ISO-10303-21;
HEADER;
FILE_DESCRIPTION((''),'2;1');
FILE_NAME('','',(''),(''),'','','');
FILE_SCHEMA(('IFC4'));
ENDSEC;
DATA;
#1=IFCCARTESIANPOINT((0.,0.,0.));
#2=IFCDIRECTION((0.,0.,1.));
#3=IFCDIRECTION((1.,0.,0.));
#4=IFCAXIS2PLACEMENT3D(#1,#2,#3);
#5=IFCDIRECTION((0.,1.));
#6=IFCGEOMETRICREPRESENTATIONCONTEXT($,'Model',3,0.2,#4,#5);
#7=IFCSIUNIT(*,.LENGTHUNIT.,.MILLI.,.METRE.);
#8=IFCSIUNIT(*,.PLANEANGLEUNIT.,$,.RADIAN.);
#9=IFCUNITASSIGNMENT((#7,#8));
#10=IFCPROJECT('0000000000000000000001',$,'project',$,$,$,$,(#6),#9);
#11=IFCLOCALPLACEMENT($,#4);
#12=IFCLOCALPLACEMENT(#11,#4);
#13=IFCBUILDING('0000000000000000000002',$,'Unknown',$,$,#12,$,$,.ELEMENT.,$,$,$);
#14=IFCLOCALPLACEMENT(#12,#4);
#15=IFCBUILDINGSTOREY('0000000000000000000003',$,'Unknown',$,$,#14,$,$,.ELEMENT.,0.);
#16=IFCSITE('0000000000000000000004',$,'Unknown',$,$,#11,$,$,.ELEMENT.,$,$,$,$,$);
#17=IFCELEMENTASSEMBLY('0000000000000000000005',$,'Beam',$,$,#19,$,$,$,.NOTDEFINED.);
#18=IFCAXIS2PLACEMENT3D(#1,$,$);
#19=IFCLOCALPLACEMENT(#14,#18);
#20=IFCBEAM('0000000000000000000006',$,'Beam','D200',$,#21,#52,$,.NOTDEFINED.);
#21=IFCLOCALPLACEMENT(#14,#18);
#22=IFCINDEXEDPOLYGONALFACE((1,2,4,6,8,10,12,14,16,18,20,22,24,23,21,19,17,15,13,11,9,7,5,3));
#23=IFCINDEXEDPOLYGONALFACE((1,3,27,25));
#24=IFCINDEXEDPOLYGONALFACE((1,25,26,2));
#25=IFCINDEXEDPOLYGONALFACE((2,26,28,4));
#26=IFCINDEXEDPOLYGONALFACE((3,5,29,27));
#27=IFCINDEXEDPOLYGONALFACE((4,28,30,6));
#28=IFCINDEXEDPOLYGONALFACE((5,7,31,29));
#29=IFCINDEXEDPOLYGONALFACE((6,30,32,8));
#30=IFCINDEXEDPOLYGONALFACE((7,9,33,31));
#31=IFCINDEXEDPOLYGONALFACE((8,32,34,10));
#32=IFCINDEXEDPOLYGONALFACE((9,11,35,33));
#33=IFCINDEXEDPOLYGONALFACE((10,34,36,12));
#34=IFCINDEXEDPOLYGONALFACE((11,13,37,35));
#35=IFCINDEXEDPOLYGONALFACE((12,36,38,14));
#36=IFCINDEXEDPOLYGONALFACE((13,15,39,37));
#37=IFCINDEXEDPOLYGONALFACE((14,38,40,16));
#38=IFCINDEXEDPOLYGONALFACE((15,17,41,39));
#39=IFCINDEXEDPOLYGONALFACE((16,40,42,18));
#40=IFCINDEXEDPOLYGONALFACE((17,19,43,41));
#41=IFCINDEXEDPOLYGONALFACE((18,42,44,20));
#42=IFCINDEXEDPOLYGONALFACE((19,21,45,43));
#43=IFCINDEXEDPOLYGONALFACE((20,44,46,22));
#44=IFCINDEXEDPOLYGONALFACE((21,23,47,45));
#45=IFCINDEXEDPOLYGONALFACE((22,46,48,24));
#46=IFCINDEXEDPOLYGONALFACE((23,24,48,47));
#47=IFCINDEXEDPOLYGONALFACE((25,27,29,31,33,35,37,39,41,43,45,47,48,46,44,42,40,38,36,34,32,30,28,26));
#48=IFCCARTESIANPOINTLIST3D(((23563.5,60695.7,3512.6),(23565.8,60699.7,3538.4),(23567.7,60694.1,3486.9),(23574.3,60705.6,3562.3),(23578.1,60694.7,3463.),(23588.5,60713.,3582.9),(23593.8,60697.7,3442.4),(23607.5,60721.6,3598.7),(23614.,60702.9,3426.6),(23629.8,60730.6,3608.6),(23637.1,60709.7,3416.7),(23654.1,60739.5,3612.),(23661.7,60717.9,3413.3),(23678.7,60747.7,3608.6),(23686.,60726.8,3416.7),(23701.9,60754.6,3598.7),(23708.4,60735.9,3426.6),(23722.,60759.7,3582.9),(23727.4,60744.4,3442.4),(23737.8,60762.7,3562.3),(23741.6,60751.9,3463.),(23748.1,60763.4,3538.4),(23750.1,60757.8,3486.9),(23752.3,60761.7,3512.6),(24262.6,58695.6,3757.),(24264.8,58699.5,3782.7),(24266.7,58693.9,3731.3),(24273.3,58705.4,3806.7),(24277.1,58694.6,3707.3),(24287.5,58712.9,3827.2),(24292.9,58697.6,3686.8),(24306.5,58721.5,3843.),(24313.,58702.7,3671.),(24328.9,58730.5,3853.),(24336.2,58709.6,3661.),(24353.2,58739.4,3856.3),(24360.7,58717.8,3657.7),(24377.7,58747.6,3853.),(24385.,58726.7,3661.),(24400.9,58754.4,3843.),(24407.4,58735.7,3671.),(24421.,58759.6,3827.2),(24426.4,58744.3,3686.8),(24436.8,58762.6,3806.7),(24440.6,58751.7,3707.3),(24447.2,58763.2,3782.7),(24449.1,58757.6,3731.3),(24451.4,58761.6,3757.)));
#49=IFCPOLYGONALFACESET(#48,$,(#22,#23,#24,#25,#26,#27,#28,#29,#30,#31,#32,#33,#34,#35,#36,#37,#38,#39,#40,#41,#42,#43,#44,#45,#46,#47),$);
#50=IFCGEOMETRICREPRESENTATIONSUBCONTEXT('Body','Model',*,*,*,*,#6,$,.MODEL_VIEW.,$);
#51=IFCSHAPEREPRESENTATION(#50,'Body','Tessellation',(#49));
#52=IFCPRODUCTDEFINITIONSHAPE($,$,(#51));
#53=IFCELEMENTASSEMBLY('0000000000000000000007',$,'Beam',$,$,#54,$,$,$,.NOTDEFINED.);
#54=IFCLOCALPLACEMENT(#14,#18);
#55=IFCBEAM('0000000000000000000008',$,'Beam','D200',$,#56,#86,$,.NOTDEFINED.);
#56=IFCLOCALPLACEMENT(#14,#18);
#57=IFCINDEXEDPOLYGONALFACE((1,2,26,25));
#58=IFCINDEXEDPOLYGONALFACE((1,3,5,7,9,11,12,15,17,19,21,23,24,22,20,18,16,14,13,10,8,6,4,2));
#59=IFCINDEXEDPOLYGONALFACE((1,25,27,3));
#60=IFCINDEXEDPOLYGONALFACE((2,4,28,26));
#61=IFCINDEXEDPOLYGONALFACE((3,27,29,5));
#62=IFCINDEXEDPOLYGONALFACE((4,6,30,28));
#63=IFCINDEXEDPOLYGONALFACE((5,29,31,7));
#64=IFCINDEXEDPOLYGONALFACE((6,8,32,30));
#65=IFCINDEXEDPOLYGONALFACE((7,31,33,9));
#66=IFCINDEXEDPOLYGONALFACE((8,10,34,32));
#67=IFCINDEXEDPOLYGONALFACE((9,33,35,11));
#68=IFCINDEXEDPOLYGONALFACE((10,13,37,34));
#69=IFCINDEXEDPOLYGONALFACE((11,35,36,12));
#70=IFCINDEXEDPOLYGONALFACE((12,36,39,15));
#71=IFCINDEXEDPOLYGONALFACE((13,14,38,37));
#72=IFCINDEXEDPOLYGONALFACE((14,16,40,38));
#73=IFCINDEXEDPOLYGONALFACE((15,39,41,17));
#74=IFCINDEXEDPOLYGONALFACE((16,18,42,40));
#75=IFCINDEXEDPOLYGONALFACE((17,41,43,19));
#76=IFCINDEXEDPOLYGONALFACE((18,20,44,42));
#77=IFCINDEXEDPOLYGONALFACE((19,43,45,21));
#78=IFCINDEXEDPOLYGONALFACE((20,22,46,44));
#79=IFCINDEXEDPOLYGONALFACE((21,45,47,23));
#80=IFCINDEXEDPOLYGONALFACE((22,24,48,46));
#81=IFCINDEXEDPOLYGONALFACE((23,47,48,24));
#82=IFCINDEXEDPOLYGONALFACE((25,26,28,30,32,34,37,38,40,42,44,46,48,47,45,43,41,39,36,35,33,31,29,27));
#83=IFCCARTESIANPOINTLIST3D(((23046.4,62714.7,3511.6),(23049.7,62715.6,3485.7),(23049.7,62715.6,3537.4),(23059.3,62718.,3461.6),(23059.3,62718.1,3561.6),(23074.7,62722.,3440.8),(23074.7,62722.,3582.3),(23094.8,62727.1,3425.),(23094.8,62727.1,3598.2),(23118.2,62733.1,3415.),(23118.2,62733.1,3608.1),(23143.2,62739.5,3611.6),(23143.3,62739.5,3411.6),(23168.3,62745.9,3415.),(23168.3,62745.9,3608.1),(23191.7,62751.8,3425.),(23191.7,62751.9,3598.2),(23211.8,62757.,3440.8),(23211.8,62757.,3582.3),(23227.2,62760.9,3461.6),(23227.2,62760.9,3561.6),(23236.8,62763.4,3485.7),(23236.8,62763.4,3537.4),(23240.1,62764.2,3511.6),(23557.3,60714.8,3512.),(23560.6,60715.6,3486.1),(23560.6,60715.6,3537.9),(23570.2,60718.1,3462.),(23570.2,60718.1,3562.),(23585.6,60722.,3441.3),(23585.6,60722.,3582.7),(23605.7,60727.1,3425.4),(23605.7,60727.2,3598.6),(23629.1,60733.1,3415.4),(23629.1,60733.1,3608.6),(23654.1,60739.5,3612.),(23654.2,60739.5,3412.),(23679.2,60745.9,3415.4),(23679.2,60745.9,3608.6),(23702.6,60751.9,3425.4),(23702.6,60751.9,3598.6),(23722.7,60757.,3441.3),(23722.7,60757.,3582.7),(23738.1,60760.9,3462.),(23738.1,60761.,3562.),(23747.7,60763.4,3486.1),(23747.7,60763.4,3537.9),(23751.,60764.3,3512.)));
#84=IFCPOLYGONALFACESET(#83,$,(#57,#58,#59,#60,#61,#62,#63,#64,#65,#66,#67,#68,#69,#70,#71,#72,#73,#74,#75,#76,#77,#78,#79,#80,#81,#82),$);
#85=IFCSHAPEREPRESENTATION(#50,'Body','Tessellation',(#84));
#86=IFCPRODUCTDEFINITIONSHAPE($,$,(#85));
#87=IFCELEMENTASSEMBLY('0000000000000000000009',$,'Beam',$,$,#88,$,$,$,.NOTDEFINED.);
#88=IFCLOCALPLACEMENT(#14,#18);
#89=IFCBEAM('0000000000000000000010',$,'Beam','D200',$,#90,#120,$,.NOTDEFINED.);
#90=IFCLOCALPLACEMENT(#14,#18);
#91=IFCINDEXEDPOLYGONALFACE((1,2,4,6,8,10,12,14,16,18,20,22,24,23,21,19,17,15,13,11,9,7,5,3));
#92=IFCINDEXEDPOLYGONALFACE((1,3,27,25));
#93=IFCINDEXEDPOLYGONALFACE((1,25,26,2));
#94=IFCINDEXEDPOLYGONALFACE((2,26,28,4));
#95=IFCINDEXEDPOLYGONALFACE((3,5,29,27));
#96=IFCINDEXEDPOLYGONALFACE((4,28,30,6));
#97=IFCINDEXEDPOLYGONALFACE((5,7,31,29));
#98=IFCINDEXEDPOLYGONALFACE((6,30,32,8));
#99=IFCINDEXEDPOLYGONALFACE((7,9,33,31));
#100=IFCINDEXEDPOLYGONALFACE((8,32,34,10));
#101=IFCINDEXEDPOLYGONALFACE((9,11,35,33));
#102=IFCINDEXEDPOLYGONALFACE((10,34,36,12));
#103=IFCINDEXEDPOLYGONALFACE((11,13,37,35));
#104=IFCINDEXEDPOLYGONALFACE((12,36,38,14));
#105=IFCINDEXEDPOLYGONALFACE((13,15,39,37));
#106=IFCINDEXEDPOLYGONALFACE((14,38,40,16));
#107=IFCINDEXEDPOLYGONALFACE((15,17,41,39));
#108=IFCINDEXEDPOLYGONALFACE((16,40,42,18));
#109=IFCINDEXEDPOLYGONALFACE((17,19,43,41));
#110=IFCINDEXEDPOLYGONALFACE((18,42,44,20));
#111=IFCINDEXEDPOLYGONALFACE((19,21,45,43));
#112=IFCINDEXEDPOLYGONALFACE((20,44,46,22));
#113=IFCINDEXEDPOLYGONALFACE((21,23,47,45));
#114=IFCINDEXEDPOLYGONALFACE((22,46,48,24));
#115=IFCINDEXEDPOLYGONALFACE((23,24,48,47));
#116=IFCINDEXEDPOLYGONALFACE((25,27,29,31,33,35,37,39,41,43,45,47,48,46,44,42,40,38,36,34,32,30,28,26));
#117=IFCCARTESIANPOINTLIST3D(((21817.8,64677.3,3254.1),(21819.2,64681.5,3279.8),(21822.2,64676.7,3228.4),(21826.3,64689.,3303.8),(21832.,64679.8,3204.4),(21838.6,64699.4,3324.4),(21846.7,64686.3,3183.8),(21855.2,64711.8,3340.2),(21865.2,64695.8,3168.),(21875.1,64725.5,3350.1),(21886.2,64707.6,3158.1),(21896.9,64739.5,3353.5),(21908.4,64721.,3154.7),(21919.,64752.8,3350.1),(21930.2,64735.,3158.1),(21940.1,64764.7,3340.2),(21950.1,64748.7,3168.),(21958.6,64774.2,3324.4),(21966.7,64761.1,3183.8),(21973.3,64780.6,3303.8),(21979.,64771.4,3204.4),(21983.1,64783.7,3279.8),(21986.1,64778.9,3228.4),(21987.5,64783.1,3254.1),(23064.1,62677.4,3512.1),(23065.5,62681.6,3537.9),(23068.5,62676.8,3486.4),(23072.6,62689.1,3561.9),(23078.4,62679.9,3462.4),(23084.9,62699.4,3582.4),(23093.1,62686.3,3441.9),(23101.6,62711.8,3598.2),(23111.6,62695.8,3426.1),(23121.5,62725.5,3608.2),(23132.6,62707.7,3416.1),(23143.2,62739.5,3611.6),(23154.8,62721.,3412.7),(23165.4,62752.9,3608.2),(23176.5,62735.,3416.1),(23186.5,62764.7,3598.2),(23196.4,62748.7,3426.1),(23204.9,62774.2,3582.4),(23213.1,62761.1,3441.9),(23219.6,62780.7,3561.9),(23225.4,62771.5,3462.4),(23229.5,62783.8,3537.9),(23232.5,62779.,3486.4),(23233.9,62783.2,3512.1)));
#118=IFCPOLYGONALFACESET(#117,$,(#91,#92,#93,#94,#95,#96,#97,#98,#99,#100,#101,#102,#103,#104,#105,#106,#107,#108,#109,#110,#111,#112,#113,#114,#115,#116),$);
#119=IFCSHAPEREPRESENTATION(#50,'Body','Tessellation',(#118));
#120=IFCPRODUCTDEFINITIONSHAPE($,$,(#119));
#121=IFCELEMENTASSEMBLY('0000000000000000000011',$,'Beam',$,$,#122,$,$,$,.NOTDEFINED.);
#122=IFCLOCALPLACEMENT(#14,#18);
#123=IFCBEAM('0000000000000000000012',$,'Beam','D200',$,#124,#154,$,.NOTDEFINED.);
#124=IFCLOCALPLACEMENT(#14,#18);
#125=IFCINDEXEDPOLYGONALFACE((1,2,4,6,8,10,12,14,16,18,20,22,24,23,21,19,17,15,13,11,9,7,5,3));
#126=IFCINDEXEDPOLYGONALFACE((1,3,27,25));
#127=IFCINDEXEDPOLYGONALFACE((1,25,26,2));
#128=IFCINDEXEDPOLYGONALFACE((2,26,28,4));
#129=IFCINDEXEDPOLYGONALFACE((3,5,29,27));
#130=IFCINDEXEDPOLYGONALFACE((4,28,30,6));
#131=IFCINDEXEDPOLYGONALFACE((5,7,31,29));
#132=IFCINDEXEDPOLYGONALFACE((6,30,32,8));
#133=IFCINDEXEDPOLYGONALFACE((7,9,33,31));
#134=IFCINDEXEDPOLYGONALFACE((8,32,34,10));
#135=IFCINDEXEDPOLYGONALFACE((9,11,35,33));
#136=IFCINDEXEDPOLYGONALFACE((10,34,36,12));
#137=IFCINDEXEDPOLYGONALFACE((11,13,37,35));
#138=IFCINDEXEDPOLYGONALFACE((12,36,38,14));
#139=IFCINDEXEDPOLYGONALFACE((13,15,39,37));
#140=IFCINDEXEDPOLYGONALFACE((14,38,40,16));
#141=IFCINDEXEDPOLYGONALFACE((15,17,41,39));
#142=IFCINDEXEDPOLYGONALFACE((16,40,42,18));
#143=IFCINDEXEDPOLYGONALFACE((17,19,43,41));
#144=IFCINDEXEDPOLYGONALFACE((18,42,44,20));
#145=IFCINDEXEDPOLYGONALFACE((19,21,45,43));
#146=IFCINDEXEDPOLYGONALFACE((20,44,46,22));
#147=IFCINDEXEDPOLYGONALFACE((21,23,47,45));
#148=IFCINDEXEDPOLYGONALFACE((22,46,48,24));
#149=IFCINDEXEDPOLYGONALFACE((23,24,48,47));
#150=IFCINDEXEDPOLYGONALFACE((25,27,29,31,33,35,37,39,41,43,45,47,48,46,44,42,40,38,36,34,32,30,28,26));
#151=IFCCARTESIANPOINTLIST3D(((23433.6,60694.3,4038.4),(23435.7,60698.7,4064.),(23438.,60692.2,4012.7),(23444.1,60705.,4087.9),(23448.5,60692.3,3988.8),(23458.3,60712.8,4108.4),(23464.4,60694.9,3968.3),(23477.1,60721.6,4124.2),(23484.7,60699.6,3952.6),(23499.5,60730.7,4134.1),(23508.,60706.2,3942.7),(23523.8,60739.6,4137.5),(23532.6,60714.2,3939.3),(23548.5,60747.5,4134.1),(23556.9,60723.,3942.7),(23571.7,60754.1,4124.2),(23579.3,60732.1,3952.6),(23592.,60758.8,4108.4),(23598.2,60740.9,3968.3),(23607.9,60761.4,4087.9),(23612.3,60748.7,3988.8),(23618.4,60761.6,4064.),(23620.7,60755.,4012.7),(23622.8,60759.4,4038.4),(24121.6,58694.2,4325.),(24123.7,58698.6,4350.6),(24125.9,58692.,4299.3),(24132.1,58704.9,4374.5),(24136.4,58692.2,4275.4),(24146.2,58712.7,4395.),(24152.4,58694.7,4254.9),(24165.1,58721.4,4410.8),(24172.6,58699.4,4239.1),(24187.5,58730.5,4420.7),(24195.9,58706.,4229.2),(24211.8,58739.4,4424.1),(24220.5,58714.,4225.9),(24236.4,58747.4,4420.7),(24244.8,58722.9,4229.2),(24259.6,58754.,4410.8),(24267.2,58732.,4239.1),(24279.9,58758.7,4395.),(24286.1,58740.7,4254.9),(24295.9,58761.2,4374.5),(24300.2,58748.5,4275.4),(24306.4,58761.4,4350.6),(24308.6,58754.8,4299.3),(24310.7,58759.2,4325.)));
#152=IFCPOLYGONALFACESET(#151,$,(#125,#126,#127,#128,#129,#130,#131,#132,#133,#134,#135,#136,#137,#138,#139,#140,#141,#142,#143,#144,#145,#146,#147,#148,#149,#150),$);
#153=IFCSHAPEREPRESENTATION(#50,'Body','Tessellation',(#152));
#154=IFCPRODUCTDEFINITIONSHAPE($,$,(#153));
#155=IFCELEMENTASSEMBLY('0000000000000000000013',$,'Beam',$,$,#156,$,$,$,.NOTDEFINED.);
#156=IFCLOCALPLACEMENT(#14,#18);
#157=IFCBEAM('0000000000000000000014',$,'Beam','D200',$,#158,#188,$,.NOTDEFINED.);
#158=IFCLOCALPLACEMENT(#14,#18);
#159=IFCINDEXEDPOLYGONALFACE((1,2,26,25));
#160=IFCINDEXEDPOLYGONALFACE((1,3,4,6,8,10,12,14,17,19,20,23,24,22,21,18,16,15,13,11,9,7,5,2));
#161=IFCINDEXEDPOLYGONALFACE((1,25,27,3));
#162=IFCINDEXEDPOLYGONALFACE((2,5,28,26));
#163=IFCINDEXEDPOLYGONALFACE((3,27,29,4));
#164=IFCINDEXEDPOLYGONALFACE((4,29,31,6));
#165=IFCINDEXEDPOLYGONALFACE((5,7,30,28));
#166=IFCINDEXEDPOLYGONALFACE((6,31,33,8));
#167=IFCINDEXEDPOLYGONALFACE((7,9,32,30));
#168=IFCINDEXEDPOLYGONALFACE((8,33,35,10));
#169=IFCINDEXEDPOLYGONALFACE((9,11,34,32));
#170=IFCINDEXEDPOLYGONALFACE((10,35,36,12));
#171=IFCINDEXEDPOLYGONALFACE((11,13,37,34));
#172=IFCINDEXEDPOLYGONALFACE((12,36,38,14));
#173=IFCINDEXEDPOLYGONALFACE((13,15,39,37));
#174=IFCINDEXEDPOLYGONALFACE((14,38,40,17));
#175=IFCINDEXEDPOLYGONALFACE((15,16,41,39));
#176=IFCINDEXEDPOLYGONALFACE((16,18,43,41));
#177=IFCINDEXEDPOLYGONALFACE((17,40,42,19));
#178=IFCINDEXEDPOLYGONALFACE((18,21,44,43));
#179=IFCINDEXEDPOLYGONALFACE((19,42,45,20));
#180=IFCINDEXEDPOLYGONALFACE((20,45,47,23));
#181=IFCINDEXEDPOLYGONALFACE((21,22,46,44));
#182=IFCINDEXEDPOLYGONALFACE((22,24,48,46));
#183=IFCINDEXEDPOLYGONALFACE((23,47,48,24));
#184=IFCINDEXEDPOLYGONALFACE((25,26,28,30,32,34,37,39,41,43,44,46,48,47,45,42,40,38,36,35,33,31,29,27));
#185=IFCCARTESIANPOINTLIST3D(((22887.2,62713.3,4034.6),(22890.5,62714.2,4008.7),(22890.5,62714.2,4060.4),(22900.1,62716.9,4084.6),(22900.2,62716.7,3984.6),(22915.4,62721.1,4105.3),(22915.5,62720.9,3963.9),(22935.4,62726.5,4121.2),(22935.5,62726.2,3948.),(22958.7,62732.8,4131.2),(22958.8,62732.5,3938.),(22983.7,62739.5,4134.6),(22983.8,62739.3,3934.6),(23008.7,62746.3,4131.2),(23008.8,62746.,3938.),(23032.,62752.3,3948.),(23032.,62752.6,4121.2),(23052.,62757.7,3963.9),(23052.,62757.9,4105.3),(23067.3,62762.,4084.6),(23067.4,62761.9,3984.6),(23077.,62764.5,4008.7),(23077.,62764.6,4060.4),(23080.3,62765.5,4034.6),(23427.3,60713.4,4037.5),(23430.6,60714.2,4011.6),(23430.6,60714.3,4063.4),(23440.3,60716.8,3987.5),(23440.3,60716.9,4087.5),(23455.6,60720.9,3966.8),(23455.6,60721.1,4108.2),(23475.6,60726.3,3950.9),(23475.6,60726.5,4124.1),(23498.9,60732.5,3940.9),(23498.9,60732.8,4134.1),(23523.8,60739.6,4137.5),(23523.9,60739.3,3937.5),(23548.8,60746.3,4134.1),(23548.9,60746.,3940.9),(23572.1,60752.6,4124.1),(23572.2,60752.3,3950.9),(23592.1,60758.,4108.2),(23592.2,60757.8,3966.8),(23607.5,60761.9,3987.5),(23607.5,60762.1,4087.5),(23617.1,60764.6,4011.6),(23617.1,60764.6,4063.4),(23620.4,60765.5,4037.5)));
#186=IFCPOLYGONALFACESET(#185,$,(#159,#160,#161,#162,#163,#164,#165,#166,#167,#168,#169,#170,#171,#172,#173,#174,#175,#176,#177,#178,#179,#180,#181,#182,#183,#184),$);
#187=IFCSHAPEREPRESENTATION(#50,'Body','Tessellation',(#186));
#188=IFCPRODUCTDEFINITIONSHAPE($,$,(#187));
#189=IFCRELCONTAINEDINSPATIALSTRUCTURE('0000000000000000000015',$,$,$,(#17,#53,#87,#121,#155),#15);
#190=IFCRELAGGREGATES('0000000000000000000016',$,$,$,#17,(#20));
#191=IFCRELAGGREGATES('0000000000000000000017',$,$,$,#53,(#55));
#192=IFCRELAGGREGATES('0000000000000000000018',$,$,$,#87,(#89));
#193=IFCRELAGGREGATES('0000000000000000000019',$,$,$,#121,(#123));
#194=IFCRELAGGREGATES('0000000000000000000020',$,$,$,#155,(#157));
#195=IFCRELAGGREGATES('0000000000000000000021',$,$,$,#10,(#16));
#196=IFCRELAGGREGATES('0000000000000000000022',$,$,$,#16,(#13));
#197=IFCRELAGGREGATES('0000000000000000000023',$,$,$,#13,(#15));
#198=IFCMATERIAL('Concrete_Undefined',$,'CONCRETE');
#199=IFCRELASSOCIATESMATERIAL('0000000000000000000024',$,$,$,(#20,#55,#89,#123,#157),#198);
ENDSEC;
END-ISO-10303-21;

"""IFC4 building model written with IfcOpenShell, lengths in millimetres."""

from ifc_helpers import new_model, si_unit, direction, frame, origin_with_axes, place, context, subcontext, project, spatial, line, indexed_curve, outline, extrude, material, element, aggregate, save


model = new_model("IFC4")

# Units and contexts
model_context = context("Model", 3, precision=0.2, world=origin_with_axes(), true_north=direction((0.0, 1.0)))
body_context = subcontext(model_context, "Body", "Model", "MODEL_VIEW")
ifc_project = project(units=[si_unit("LENGTHUNIT", "METRE", prefix="MILLI"), si_unit("PLANEANGLEUNIT", "RADIAN")], contexts=[model_context])

# Site, building, storey
site_placement = place(None, origin_with_axes())
site = spatial("IfcSite", under=ifc_project, at=site_placement, Name="Unknown", CompositionType="ELEMENT")
building_placement = place(site_placement, origin_with_axes())
building = spatial("IfcBuilding", under=site, at=building_placement, Name="Unknown", CompositionType="ELEMENT")
storey_placement = place(building_placement, origin_with_axes())
storey = spatial("IfcBuildingStorey", under=building, at=storey_placement, Name="Unknown", CompositionType="ELEMENT", Elevation=0.0)

# Element assemblies, beams
ifc_material = material(Name="Concrete_Undefined", Category="CONCRETE")
assembly_1_placement = place(storey_placement, frame((23657.9, 60728.7, 3512.6), z_axis=(-0.944009, -0.329921, 0.0), x_axis=(0.327748, -0.937792, 0.114571)))
assembly_1 = element("IfcElementAssembly", 1, at=assembly_1_placement, inside=storey, Name="Beam", PredefinedType="NOTDEFINED")
beam_1_placement = place(assembly_1_placement, origin_with_axes())
beam_1 = element("IfcBeam", 2, at=beam_1_placement, material=ifc_material, Name="Beam", Description="D200", PredefinedType="NOTDEFINED", context=body_context, shape_type="SolidModel", body=[
    extrude(outline(indexed_curve([(100.0, 0.0), (96.6, 25.9), (86.6, 50.0), (70.7, 70.7), (50.0, 86.6), (25.9, 96.6), (0.0, 100.0), (-25.9, 96.6), (-50.0, 86.6), (-70.7, 70.7), (-86.6, 50.0), (-96.6, 25.9), (-100.0, 0.0), (-96.6, -25.9), (-86.6, -50.0), (-70.7, -70.7), (-50.0, -86.6), (-25.9, -96.6), (0.0, -100.0), (25.9, -96.6), (50.0, -86.6), (70.7, -70.7), (86.6, -50.0), (96.6, -25.9)], segments=[line(1, 2, 3, 4, 5, 6, 7, 8, 9, 10, 11, 12, 13, 14, 15, 16, 17, 18, 19, 20, 21, 22, 23, 24, 1)])), frame((0.0, 0.0, 0.0), z_axis=(-1.0, 0.0, 0.0), x_axis=(0.0, 0.0, 1.0)), (0.0, 0.0, -1.0), 2132.8),
])
aggregate(assembly_1, [beam_1])
assembly_2_placement = place(storey_placement, frame((23143.3, 62739.5, 3511.6), z_axis=(-0.968887, -0.247504, 0.0), x_axis=(0.247504, -0.968887, 0.000208)))
assembly_2 = element("IfcElementAssembly", 3, at=assembly_2_placement, inside=storey, Name="Beam", PredefinedType="NOTDEFINED")
beam_2_placement = place(assembly_2_placement, origin_with_axes())
beam_2 = element("IfcBeam", 4, at=beam_2_placement, material=ifc_material, Name="Beam", Description="D200", PredefinedType="NOTDEFINED", context=body_context, shape_type="SolidModel", body=[
    extrude(outline(indexed_curve([(100.0, 0.0), (96.6, 25.9), (86.6, 50.0), (70.7, 70.7), (50.0, 86.6), (25.9, 96.6), (0.0, 100.0), (-25.9, 96.6), (-50.0, 86.6), (-70.7, 70.7), (-86.6, 50.0), (-96.6, 25.9), (-100.0, 0.0), (-96.6, -25.9), (-86.6, -50.0), (-70.7, -70.7), (-50.0, -86.6), (-25.9, -96.6), (0.0, -100.0), (25.9, -96.6), (50.0, -86.6), (70.7, -70.7), (86.6, -50.0), (96.6, -25.9)], segments=[line(1, 2, 3, 4, 5, 6, 7, 8, 9, 10, 11, 12, 13, 14, 15, 16, 17, 18, 19, 20, 21, 22, 23, 24, 1)])), frame((0.0, 0.0, 0.0), z_axis=(-1.0, 0.0, 0.0), x_axis=(0.0, 0.0, 1.0)), (0.0, 0.0, -1.0), 2064.2),
])
aggregate(assembly_2, [beam_2])
assembly_3_placement = place(storey_placement, frame((21902.6, 64730.2, 3254.1), z_axis=(-0.848685, -0.528898, 0.0), x_axis=(0.525756, -0.843642, 0.10885)))
assembly_3 = element("IfcElementAssembly", 5, at=assembly_3_placement, inside=storey, Name="Beam", PredefinedType="NOTDEFINED")
beam_3_placement = place(assembly_3_placement, origin_with_axes())
beam_3 = element("IfcBeam", 6, at=beam_3_placement, material=ifc_material, Name="Beam", Description="D200", PredefinedType="NOTDEFINED", context=body_context, shape_type="SolidModel", body=[
    extrude(outline(indexed_curve([(100.0, 0.0), (96.6, 25.9), (86.6, 50.0), (70.7, 70.7), (50.0, 86.6), (25.9, 96.6), (0.0, 100.0), (-25.9, 96.6), (-50.0, 86.6), (-70.7, 70.7), (-86.6, 50.0), (-96.6, 25.9), (-100.0, 0.0), (-96.6, -25.9), (-86.6, -50.0), (-70.7, -70.7), (-50.0, -86.6), (-25.9, -96.6), (0.0, -100.0), (25.9, -96.6), (50.0, -86.6), (70.7, -70.7), (86.6, -50.0), (96.6, -25.9)], segments=[line(1, 2, 3, 4, 5, 6, 7, 8, 9, 10, 11, 12, 13, 14, 15, 16, 17, 18, 19, 20, 21, 22, 23, 24, 1)])), frame((0.0, 0.0, 0.0), z_axis=(-1.0, 0.0, 0.0), x_axis=(0.0, 0.0, 1.0)), (0.0, 0.0, -1.0), 2370.6),
])
aggregate(assembly_3, [beam_3])
assembly_4_placement = place(storey_placement, frame((23528.2, 60726.9, 4038.4), z_axis=(-0.945632, -0.325239, 0.0), x_axis=(0.322294, -0.93707, 0.134262)))
assembly_4 = element("IfcElementAssembly", 7, at=assembly_4_placement, inside=storey, Name="Beam", PredefinedType="NOTDEFINED")
beam_4_placement = place(assembly_4_placement, origin_with_axes())
beam_4 = element("IfcBeam", 8, at=beam_4_placement, material=ifc_material, Name="Beam", Description="D200", PredefinedType="NOTDEFINED", context=body_context, shape_type="SolidModel", body=[
    extrude(outline(indexed_curve([(100.0, 0.0), (96.6, 25.9), (86.6, 50.0), (70.7, 70.7), (50.0, 86.6), (25.9, 96.6), (0.0, 100.0), (-25.9, 96.6), (-50.0, 86.6), (-70.7, 70.7), (-86.6, 50.0), (-96.6, 25.9), (-100.0, 0.0), (-96.6, -25.9), (-86.6, -50.0), (-70.7, -70.7), (-50.0, -86.6), (-25.9, -96.6), (0.0, -100.0), (25.9, -96.6), (50.0, -86.6), (70.7, -70.7), (86.6, -50.0), (96.6, -25.9)], segments=[line(1, 2, 3, 4, 5, 6, 7, 8, 9, 10, 11, 12, 13, 14, 15, 16, 17, 18, 19, 20, 21, 22, 23, 24, 1)])), frame((0.0, 0.0, 0.0), z_axis=(-1.0, 0.0, 0.0), x_axis=(0.0, 0.0, 1.0)), (0.0, 0.0, -1.0), 2134.5),
])
aggregate(assembly_4, [beam_4])
assembly_5_placement = place(storey_placement, frame((22983.7, 62739.4, 4034.6), z_axis=(-0.965411, -0.260732, 0.0), x_axis=(0.260732, -0.96541, 0.001403)))
assembly_5 = element("IfcElementAssembly", 9, at=assembly_5_placement, inside=storey, Name="Beam", PredefinedType="NOTDEFINED")
beam_5_placement = place(assembly_5_placement, origin_with_axes())
beam_5 = element("IfcBeam", 10, at=beam_5_placement, material=ifc_material, Name="Beam", Description="D200", PredefinedType="NOTDEFINED", context=body_context, shape_type="SolidModel", body=[
    extrude(outline(indexed_curve([(100.0, 0.0), (96.6, 25.9), (86.6, 50.0), (70.7, 70.7), (50.0, 86.6), (25.9, 96.6), (0.0, 100.0), (-25.9, 96.6), (-50.0, 86.6), (-70.7, 70.7), (-86.6, 50.0), (-96.6, 25.9), (-100.0, 0.0), (-96.6, -25.9), (-86.6, -50.0), (-70.7, -70.7), (-50.0, -86.6), (-25.9, -96.6), (0.0, -100.0), (25.9, -96.6), (50.0, -86.6), (70.7, -70.7), (86.6, -50.0), (96.6, -25.9)], segments=[line(1, 2, 3, 4, 5, 6, 7, 8, 9, 10, 11, 12, 13, 14, 15, 16, 17, 18, 19, 20, 21, 22, 23, 24, 1)])), frame((0.0, 0.0, 0.0), z_axis=(-1.0, 0.0, 0.0), x_axis=(0.0, 0.0, 1.0)), (0.0, 0.0, -1.0), 2071.6),
])
aggregate(assembly_5, [beam_5])

save(model, "model.ifc")
